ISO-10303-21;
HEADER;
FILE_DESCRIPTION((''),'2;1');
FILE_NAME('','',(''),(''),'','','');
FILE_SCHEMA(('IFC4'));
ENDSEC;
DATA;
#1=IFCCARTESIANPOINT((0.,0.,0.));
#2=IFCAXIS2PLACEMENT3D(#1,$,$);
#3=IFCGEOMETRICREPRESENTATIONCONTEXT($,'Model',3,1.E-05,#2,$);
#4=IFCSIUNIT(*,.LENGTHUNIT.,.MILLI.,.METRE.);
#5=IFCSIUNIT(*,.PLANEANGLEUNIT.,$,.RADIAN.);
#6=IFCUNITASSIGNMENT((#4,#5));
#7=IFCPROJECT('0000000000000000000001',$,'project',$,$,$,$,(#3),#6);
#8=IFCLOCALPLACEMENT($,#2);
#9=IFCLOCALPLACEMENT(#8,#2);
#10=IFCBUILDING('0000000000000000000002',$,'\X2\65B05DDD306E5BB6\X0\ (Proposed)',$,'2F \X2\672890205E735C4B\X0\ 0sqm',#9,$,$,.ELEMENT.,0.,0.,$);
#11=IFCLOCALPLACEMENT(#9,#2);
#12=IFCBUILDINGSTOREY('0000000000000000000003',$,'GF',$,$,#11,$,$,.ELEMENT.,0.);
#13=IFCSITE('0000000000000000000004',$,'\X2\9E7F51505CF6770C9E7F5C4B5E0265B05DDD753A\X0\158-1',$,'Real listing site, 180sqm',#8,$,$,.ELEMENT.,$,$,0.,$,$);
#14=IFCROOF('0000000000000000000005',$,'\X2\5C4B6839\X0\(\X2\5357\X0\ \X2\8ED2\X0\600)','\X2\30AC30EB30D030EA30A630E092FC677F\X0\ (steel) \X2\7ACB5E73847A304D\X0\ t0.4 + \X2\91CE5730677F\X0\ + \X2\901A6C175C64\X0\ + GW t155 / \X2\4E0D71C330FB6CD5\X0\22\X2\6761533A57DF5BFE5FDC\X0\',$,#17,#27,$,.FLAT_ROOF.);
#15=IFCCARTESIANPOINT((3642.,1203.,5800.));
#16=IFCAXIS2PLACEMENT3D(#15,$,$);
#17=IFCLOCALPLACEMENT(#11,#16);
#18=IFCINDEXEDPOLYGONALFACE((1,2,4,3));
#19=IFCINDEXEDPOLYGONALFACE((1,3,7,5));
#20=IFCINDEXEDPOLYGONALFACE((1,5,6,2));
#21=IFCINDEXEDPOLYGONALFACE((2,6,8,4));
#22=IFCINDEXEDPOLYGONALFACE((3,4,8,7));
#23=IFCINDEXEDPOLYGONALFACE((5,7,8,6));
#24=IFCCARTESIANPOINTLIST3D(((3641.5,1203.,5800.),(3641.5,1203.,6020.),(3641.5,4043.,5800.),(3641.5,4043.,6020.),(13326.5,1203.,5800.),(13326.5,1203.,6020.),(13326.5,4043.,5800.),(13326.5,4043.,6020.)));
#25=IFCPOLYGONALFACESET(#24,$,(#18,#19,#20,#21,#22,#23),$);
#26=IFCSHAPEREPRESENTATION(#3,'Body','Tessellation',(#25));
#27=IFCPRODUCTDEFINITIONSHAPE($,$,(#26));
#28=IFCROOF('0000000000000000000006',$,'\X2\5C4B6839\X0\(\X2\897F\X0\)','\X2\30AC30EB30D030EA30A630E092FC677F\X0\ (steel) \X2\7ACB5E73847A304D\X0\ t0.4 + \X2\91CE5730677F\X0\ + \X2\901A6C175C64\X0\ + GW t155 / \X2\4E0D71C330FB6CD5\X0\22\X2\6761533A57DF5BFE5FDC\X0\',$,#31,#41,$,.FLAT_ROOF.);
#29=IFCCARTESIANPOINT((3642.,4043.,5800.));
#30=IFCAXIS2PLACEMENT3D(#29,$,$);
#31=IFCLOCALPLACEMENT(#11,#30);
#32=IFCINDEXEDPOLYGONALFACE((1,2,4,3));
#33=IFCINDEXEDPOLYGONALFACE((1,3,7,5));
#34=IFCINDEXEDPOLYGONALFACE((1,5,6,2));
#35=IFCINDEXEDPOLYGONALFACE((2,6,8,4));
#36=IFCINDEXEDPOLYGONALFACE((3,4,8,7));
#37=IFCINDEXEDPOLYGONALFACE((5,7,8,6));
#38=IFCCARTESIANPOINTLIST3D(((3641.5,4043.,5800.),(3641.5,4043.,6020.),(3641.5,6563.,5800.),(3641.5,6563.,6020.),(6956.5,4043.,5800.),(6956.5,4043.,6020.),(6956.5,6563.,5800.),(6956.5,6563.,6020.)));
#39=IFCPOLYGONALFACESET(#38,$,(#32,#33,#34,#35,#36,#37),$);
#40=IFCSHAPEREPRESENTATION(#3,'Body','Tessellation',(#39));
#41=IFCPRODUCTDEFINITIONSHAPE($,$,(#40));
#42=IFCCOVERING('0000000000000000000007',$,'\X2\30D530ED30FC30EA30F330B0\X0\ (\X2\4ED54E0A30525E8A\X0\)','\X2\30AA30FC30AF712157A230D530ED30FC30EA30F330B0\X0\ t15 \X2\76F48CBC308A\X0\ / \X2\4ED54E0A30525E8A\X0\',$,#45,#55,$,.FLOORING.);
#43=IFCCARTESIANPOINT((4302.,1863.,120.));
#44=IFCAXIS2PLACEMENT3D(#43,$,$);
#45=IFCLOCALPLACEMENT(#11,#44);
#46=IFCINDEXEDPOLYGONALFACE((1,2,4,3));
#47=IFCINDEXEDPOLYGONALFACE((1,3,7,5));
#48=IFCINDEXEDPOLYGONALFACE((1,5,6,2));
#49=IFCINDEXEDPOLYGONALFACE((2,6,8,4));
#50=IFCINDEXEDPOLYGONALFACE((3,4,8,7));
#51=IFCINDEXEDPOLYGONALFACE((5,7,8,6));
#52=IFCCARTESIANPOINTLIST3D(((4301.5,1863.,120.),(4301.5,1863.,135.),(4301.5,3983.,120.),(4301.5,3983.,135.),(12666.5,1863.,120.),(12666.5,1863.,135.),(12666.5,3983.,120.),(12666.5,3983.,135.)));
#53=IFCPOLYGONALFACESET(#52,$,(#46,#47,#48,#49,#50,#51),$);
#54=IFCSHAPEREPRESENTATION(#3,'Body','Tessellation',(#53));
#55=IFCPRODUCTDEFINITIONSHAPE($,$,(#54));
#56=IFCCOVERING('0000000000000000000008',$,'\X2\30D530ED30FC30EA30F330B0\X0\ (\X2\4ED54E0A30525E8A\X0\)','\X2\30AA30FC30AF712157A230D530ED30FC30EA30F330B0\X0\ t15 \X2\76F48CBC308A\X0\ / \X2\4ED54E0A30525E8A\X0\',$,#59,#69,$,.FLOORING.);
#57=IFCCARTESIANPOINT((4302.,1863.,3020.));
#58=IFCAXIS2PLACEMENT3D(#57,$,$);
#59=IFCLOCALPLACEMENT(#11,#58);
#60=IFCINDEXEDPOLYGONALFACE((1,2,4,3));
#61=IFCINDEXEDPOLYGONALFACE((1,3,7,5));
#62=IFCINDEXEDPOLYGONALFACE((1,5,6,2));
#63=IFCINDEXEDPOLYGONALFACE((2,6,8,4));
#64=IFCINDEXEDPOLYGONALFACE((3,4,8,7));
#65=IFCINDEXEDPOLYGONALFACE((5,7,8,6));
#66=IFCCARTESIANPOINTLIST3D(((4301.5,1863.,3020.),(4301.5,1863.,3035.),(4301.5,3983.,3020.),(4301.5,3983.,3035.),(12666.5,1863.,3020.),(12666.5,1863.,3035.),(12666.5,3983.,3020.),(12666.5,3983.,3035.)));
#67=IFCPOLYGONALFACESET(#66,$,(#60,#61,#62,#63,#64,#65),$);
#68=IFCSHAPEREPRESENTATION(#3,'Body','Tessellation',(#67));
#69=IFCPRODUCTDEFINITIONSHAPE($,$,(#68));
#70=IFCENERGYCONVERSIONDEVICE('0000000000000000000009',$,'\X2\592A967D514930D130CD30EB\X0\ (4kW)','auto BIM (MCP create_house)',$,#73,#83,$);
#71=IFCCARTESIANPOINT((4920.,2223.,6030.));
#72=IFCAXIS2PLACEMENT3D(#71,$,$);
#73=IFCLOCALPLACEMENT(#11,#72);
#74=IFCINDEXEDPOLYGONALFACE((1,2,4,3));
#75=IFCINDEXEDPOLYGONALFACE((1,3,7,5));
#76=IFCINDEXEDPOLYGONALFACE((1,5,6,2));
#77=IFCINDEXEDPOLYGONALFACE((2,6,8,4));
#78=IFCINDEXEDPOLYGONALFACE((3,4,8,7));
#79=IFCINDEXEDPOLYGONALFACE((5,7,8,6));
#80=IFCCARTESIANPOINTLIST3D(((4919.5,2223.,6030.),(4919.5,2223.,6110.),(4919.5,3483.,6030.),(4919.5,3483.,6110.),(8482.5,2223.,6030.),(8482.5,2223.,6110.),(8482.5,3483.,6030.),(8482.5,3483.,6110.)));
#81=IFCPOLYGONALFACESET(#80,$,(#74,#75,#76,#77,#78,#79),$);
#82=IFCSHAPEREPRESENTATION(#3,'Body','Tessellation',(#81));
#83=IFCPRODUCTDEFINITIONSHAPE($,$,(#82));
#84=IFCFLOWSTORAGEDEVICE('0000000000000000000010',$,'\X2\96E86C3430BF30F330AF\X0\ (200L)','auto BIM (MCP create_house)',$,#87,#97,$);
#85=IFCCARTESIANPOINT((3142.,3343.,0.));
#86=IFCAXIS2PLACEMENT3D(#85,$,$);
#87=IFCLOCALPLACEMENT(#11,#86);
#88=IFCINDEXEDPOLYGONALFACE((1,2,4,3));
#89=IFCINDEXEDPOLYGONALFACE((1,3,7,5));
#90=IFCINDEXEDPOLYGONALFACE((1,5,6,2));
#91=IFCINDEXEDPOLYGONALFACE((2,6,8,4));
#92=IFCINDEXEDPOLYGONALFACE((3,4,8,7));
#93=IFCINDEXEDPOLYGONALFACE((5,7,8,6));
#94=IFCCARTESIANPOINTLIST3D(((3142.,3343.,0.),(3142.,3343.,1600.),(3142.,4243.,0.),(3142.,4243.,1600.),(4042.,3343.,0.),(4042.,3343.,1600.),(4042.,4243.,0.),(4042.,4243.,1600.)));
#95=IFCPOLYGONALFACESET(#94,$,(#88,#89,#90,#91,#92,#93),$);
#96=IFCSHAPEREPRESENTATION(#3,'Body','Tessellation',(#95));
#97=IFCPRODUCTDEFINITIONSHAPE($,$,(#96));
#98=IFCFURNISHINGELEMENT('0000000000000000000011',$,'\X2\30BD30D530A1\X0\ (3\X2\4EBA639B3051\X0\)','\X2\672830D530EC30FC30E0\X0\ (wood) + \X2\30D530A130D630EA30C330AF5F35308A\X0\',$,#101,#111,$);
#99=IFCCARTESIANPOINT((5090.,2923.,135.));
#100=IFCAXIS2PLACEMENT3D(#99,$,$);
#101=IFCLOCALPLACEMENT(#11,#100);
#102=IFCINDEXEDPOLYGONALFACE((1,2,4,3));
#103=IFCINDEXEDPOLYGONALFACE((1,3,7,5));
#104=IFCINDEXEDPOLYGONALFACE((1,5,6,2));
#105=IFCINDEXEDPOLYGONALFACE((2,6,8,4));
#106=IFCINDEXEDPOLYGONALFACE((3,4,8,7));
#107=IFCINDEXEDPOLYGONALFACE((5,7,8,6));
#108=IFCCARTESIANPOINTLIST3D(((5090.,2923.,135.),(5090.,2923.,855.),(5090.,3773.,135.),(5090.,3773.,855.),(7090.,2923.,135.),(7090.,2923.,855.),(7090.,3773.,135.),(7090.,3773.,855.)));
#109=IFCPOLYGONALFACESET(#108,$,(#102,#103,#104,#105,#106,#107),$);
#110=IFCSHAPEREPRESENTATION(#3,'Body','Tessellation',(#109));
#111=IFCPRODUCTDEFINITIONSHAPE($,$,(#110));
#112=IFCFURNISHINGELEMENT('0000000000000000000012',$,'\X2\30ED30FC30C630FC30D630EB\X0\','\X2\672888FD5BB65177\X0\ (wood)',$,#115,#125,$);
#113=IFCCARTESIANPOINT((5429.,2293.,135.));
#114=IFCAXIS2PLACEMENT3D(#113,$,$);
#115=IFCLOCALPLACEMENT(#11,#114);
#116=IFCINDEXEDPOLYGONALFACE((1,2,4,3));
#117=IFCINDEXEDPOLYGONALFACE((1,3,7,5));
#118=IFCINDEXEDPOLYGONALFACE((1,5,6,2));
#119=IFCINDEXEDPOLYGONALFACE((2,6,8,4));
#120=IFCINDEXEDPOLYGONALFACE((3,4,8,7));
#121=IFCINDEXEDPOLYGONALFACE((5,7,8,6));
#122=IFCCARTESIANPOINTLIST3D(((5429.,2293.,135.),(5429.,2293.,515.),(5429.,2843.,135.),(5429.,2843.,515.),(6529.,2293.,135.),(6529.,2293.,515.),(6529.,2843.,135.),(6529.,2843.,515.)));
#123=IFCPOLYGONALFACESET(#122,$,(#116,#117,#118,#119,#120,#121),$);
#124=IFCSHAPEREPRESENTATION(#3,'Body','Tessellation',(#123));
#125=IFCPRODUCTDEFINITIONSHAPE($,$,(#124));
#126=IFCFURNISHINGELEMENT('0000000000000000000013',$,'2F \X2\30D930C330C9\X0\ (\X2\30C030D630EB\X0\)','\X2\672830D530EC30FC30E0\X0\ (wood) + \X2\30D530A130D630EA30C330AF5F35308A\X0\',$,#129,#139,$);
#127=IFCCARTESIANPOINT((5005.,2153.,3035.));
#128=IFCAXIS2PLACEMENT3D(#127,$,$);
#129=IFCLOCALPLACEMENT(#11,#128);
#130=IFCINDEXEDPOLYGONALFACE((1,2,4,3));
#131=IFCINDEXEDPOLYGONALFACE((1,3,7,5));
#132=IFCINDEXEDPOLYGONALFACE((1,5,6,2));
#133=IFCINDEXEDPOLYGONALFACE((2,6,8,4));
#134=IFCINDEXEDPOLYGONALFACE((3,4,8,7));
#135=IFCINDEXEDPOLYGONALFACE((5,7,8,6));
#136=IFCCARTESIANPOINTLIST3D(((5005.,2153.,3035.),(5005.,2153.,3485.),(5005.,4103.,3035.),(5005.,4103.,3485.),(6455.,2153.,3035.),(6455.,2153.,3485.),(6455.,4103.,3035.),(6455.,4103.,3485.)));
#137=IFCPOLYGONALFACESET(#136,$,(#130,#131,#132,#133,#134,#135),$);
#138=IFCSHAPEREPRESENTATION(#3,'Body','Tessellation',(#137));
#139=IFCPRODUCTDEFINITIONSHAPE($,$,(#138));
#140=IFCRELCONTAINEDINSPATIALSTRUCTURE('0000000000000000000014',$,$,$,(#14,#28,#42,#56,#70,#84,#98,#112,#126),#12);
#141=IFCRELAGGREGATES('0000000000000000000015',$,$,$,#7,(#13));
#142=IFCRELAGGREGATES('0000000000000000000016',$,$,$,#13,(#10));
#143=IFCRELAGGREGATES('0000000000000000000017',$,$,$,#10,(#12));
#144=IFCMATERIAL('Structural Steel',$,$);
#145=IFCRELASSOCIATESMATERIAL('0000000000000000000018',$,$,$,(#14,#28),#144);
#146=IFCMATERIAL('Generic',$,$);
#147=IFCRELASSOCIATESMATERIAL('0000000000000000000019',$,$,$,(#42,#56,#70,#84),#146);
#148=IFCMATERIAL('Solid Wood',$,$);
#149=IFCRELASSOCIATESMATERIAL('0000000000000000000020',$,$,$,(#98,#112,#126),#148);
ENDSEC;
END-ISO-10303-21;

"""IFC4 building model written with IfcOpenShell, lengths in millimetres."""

from ifc_helpers import new_model, si_unit, frame, frame_2d, origin, place, context, project, spatial, rectangle, extrude, material, element, save


model = new_model("IFC4")

# Units and contexts
model_context = context("Model", 3, precision=1e-05, world=origin())
ifc_project = project(units=[si_unit("LENGTHUNIT", "METRE", prefix="MILLI"), si_unit("PLANEANGLEUNIT", "RADIAN")], contexts=[model_context])

# Site, building, storey
site_placement = place(None, origin())
site = spatial("IfcSite", under=ifc_project, at=site_placement, Name="鹿児島県鹿屋市新川町158-1", ObjectType="Real listing site, 180sqm", CompositionType="ELEMENT", RefElevation=0.0)
building_placement = place(site_placement, origin())
building = spatial("IfcBuilding", under=site, at=building_placement, Name="新川の家 (Proposed)", ObjectType="2F 木造平屋 0sqm", CompositionType="ELEMENT", ElevationOfRefHeight=0.0, ElevationOfTerrain=0.0)
storey_placement = place(building_placement, origin())
storey = spatial("IfcBuildingStorey", under=building, at=storey_placement, Name="GF", CompositionType="ELEMENT", Elevation=0.0)

# Shared definitions
ifc_material_1 = material(Name="Solid Wood")

# Roofs
ifc_material_2 = material(Name="Structural Steel")
roof_1_placement = place(storey_placement, frame((3642.0, 1203.0, 5800.0)))
element("IfcRoof", 1, at=roof_1_placement, inside=storey, material=ifc_material_2, Name="屋根(南 軒600)", Description="ガルバリウム鋼板 (steel) 立平葺き t0.4 + 野地板 + 通気層 + GW t155 / 不燃・法22条区域対応", PredefinedType="FLAT_ROOF", context=model_context, shape_type="SweptSolid", body=[
    extrude(rectangle(XDim=9685.0, YDim=2840.0, at=frame_2d((4842.0, 1420.0))), frame((3642.0, 1203.0, 5800.0)), (0.0, 0.0, 1.0), 220.0),
])
roof_2_placement = place(storey_placement, frame((3642.0, 4043.0, 5800.0)))
element("IfcRoof", 2, at=roof_2_placement, inside=storey, material=ifc_material_2, Name="屋根(西)", Description="ガルバリウム鋼板 (steel) 立平葺き t0.4 + 野地板 + 通気層 + GW t155 / 不燃・法22条区域対応", PredefinedType="FLAT_ROOF", context=model_context, shape_type="SweptSolid", body=[
    extrude(rectangle(XDim=3315.0, YDim=2520.0, at=frame_2d((1657.0, 1260.0))), frame((3642.0, 4043.0, 5800.0)), (0.0, 0.0, 1.0), 220.0),
])

# Coverings
ifc_material_3 = material(Name="Generic")
covering_1_placement = place(storey_placement, frame((4302.0, 1863.0, 120.0)))
element("IfcCovering", 3, at=covering_1_placement, inside=storey, material=ifc_material_3, Name="フローリング (仕上げ床)", Description="オーク無垢フローリング t15 直貼り / 仕上げ床", PredefinedType="FLOORING", context=model_context, shape_type="SweptSolid", body=[
    extrude(rectangle(XDim=8365.0, YDim=2120.0, at=frame_2d((4182.0, 1060.0))), frame((4302.0, 1863.0, 120.0)), (0.0, 0.0, 1.0), 15.0),
])
covering_2_placement = place(storey_placement, frame((4302.0, 1863.0, 3020.0)))
element("IfcCovering", 4, at=covering_2_placement, inside=storey, material=ifc_material_3, Name="フローリング (仕上げ床)", Description="オーク無垢フローリング t15 直貼り / 仕上げ床", PredefinedType="FLOORING", context=model_context, shape_type="SweptSolid", body=[
    extrude(rectangle(XDim=8365.0, YDim=2120.0, at=frame_2d((4182.0, 1060.0))), frame((4302.0, 1863.0, 3020.0)), (0.0, 0.0, 1.0), 15.0),
])

# Energy conversion device
energy_conversion_device_placement = place(storey_placement, frame((4920.0, 2223.0, 6030.0)))
element("IfcEnergyConversionDevice", 5, at=energy_conversion_device_placement, inside=storey, material=ifc_material_3, Name="太陽光パネル (4kW)", Description="auto BIM (MCP create_house)", context=model_context, shape_type="SweptSolid", body=[
    extrude(rectangle(XDim=3563.0, YDim=1260.0, at=frame_2d((1781.0, 630.0))), frame((4920.0, 2223.0, 6030.0)), (0.0, 0.0, 1.0), 80.0),
])

# Flow storage device
flow_storage_device_placement = place(storey_placement, frame((3142.0, 3343.0, 0.0)))
element("IfcFlowStorageDevice", 6, at=flow_storage_device_placement, inside=storey, material=ifc_material_3, Name="雨水タンク (200L)", Description="auto BIM (MCP create_house)", context=model_context, shape_type="SweptSolid", body=[
    extrude(rectangle(XDim=900.0, YDim=900.0, at=frame_2d((450.0, 450.0))), frame((3142.0, 3343.0, 0.0)), (0.0, 0.0, 1.0), 1600.0),
])

# Furnishing elements
furnishing_1_placement = place(storey_placement, frame((5090.0, 2923.0, 135.0)))
element("IfcFurnishingElement", 7, at=furnishing_1_placement, inside=storey, material=ifc_material_1, Name="ソファ (3人掛け)", Description="木フレーム (wood) + ファブリック張り", context=model_context, shape_type="SweptSolid", body=[
    extrude(rectangle(XDim=2000.0, YDim=850.0, at=frame_2d((1000.0, 425.0))), frame((5090.0, 2923.0, 135.0)), (0.0, 0.0, 1.0), 720.0),
])
furnishing_2_placement = place(storey_placement, frame((5429.0, 2293.0, 135.0)))
element("IfcFurnishingElement", 8, at=furnishing_2_placement, inside=storey, material=ifc_material_1, Name="ローテーブル", Description="木製家具 (wood)", context=model_context, shape_type="SweptSolid", body=[
    extrude(rectangle(XDim=1100.0, YDim=550.0, at=frame_2d((550.0, 275.0))), frame((5429.0, 2293.0, 135.0)), (0.0, 0.0, 1.0), 380.0),
])
furnishing_3_placement = place(storey_placement, frame((5005.0, 2153.0, 3035.0)))
element("IfcFurnishingElement", 9, at=furnishing_3_placement, inside=storey, material=ifc_material_1, Name="2F ベッド (ダブル)", Description="木フレーム (wood) + ファブリック張り", context=model_context, shape_type="SweptSolid", body=[
    extrude(rectangle(XDim=1450.0, YDim=1950.0, at=frame_2d((725.0, 975.0))), frame((5005.0, 2153.0, 3035.0)), (0.0, 0.0, 1.0), 450.0),
])

save(model, "model.ifc")
